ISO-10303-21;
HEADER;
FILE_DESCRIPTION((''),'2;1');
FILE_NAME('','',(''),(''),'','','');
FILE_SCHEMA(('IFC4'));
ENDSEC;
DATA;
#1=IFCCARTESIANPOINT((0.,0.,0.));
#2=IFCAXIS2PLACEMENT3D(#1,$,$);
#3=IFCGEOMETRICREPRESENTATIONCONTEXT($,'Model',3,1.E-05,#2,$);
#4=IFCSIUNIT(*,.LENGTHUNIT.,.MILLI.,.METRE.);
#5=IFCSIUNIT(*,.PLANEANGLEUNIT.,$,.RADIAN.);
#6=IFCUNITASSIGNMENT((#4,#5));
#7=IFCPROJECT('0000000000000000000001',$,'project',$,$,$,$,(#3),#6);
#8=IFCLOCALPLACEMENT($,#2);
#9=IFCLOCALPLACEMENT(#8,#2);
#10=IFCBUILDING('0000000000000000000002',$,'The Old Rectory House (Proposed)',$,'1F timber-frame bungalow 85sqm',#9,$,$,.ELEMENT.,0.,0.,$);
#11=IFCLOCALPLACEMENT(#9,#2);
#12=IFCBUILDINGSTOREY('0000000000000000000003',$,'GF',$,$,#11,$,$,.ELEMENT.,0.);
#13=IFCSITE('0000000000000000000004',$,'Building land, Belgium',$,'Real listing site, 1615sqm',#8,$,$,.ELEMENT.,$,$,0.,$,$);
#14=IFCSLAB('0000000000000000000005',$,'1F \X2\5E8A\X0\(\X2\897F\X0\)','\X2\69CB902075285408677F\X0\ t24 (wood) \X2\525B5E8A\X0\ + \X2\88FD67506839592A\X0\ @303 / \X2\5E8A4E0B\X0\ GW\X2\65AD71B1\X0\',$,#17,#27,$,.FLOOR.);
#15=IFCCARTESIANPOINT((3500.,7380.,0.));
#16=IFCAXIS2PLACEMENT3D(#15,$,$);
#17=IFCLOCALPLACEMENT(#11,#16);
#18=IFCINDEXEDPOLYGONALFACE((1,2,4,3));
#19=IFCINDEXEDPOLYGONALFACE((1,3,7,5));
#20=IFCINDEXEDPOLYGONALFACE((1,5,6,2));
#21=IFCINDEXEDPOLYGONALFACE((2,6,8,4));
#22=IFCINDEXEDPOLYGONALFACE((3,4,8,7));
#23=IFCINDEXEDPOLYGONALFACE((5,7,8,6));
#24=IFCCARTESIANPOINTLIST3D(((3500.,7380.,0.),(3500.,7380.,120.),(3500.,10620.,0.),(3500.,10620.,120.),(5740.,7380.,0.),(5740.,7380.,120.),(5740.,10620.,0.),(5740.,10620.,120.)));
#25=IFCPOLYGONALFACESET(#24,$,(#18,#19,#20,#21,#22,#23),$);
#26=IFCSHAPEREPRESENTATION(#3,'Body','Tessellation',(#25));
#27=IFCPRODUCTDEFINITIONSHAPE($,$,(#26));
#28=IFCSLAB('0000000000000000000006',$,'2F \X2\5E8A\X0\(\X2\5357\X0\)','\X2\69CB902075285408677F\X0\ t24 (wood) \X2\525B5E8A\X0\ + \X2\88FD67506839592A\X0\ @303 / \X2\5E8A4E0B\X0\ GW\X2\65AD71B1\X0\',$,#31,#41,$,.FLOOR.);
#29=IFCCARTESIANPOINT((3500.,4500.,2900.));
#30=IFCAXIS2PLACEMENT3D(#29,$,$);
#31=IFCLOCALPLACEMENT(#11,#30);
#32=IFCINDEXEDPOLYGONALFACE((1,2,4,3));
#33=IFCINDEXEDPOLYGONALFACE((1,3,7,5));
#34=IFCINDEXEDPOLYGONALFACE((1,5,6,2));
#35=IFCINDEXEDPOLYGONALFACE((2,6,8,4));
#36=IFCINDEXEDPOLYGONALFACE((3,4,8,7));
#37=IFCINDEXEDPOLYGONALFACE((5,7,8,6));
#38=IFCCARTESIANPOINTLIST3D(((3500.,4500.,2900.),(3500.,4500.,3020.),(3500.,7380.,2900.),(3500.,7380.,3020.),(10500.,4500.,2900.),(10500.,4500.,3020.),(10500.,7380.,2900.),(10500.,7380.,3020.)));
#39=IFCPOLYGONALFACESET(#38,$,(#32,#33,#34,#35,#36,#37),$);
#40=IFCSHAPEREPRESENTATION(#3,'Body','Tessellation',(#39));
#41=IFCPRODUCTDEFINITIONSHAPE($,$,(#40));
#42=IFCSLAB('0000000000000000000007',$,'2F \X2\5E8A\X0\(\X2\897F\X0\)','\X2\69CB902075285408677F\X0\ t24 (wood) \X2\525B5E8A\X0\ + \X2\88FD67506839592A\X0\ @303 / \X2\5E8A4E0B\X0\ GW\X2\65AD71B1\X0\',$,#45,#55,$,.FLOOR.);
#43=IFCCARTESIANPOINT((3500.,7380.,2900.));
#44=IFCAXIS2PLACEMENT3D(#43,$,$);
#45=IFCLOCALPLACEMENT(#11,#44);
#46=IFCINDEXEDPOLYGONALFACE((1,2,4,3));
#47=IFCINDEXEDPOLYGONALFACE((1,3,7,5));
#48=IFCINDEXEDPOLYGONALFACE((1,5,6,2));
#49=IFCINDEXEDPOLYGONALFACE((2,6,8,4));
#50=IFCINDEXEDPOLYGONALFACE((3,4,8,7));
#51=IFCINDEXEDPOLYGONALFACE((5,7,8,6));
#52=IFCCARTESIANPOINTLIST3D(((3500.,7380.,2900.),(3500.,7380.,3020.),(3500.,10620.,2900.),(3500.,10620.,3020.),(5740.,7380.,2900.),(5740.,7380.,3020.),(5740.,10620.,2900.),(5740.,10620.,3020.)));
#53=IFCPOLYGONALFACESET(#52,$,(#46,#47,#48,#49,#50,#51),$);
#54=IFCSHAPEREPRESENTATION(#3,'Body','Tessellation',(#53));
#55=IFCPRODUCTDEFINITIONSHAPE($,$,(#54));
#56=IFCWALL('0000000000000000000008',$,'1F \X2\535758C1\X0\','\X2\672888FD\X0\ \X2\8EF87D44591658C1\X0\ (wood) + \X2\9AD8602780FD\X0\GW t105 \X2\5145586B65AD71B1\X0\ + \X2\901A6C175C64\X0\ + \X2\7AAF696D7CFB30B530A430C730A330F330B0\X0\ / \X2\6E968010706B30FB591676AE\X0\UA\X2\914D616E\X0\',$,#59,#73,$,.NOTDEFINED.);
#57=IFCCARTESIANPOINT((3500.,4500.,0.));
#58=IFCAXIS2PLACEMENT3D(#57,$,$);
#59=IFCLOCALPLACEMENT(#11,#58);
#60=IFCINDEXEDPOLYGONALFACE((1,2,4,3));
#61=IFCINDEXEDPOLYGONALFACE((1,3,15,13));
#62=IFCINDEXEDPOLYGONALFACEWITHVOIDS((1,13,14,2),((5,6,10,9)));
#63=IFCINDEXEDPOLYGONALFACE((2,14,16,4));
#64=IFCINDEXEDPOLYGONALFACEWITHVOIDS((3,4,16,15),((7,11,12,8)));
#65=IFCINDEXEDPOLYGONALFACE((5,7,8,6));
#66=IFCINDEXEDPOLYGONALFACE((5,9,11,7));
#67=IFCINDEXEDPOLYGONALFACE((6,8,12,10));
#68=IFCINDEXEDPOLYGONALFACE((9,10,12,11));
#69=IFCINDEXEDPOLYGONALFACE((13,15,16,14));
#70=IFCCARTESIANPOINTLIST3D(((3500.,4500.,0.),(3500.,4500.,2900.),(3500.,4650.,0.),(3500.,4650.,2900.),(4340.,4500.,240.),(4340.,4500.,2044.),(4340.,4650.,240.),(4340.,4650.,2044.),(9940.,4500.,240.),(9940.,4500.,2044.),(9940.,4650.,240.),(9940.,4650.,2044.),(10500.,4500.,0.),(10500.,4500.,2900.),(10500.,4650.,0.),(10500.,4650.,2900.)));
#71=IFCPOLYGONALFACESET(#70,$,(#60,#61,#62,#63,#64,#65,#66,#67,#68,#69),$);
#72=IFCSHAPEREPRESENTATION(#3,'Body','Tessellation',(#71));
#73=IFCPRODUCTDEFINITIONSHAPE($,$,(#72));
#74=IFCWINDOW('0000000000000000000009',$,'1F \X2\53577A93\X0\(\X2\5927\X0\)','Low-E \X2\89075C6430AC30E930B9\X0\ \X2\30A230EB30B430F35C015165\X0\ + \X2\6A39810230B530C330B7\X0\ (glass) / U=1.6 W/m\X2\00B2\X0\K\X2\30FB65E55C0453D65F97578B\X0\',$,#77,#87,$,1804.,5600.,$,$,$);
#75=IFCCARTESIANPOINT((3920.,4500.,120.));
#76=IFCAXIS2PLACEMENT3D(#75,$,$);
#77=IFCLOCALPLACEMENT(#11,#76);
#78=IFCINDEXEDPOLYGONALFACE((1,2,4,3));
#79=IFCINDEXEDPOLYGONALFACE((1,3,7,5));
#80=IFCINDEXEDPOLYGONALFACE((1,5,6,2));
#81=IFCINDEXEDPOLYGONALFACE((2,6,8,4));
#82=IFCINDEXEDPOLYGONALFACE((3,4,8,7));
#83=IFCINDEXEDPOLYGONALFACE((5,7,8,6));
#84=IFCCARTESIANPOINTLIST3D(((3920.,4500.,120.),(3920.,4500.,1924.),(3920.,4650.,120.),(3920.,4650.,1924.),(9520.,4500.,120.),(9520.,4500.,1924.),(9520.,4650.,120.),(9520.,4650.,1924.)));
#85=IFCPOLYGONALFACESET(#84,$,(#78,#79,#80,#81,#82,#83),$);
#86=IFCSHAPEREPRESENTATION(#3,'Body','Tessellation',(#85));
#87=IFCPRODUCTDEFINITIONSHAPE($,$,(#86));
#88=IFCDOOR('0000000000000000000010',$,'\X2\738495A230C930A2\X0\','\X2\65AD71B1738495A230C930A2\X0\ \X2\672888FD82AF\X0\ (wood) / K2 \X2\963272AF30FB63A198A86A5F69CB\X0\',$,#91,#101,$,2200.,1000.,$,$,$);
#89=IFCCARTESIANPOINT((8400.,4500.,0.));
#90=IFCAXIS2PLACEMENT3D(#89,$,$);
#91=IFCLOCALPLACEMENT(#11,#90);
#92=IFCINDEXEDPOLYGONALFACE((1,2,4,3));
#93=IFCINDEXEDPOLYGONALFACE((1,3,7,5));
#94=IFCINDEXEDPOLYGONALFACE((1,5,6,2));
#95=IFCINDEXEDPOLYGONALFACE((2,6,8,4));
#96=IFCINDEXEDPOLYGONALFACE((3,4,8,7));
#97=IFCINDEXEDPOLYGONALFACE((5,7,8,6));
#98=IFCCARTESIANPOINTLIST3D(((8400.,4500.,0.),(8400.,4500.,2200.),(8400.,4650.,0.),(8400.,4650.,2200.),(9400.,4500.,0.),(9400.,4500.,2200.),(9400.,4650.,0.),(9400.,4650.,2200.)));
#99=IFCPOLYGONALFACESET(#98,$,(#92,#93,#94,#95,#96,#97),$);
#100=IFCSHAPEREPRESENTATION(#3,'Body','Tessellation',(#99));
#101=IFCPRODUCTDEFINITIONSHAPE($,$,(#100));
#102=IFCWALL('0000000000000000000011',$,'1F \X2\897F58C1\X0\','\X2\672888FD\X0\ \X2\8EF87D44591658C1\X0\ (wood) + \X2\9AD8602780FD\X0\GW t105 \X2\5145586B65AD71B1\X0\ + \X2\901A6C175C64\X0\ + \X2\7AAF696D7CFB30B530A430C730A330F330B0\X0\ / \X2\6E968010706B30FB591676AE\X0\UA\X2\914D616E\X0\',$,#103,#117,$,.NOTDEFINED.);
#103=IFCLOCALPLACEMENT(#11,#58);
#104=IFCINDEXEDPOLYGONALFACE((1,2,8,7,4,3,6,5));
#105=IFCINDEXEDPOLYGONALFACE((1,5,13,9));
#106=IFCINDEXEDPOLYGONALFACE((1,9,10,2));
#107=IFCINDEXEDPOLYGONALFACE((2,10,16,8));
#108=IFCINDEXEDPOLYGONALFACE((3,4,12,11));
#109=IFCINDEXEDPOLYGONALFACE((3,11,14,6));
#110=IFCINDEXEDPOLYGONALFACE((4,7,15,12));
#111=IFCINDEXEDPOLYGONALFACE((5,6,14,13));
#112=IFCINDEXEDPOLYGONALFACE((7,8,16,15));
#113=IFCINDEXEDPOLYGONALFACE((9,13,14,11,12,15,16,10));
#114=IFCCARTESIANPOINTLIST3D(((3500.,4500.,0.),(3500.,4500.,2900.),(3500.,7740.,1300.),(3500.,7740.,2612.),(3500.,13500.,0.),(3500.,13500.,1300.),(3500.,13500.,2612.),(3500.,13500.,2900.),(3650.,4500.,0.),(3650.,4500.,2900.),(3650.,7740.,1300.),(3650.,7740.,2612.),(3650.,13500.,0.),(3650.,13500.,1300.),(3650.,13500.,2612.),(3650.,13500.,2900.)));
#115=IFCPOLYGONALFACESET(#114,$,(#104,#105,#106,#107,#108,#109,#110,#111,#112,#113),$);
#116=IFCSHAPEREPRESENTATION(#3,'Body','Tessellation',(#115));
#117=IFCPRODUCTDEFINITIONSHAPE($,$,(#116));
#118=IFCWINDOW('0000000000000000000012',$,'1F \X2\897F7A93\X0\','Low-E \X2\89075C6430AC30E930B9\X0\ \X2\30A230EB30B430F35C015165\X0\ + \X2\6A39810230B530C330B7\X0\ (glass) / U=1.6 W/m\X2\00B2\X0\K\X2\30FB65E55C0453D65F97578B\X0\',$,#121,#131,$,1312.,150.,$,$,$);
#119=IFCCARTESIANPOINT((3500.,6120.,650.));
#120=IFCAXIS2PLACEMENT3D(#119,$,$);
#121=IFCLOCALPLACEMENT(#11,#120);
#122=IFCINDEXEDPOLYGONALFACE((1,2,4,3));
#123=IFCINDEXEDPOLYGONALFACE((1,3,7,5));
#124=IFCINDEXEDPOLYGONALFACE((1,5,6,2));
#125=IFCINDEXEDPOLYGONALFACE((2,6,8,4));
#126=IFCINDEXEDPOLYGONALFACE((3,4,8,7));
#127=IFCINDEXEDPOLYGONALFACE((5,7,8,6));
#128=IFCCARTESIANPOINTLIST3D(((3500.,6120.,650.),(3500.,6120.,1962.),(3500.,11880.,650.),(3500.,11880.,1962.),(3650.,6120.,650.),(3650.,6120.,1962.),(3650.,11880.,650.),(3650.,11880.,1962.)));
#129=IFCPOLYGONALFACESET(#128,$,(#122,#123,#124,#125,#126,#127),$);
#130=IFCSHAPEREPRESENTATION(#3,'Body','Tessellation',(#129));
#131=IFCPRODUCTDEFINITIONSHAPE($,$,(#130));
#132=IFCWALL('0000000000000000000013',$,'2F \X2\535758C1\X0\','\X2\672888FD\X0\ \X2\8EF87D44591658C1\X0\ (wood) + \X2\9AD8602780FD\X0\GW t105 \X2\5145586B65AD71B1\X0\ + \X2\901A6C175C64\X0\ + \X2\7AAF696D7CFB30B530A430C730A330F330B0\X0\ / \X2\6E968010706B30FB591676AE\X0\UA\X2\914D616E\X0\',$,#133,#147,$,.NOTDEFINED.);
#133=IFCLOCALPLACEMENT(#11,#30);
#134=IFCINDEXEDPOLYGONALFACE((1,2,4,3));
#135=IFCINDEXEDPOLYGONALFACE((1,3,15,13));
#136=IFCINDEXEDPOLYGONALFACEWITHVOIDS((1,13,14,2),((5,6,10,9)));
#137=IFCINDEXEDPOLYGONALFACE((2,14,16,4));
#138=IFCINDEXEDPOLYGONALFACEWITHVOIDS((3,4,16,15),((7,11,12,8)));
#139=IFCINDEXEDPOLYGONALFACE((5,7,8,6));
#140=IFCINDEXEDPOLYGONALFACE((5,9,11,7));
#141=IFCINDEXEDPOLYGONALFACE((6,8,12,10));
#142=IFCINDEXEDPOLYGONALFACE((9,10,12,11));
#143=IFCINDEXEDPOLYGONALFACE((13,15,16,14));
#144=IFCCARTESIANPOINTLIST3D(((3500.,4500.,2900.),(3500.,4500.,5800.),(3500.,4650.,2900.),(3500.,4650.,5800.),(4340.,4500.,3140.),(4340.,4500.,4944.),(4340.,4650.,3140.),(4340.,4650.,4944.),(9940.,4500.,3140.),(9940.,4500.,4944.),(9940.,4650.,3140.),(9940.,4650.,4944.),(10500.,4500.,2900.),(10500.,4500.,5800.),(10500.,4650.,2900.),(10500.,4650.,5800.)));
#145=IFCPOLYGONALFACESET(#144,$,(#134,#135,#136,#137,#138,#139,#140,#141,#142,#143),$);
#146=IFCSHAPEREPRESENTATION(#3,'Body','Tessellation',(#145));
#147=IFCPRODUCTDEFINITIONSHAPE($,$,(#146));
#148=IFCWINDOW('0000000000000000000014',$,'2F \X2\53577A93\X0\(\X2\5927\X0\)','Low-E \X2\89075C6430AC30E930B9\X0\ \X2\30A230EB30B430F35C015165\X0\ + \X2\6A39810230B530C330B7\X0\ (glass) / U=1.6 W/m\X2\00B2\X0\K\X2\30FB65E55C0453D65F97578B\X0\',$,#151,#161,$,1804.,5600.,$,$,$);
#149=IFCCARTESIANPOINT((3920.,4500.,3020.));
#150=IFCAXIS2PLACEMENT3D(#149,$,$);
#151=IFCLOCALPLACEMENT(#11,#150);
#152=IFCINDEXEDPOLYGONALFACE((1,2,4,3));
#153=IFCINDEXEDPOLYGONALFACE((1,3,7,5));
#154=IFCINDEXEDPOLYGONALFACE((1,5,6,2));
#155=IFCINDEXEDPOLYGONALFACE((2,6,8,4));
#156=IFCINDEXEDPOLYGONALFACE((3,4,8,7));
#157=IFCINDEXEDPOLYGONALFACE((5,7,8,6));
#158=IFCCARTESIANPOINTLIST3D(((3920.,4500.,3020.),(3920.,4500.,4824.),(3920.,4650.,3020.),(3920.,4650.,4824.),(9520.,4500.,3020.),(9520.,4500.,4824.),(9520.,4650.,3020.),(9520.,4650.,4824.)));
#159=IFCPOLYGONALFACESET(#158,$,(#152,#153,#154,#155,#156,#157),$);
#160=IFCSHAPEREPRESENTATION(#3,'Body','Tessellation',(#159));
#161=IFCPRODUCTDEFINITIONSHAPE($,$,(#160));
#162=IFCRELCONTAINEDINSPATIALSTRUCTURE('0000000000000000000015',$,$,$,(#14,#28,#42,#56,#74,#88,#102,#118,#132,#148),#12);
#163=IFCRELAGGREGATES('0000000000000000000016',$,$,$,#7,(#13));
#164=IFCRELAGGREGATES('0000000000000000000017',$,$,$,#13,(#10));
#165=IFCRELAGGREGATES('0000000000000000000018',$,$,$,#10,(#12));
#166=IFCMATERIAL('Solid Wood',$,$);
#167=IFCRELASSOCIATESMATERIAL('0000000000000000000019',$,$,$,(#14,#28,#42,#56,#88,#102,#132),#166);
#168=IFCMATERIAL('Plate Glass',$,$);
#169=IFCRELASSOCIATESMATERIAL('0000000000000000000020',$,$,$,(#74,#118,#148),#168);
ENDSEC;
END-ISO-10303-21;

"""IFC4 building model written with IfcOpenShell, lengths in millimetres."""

from ifc_helpers import new_model, si_unit, frame, frame_2d, origin, place, context, project, spatial, rectangle, extrude, material, element, fill, save


model = new_model("IFC4")

# Units and contexts
model_context = context("Model", 3, precision=1e-05, world=origin())
ifc_project = project(units=[si_unit("LENGTHUNIT", "METRE", prefix="MILLI"), si_unit("PLANEANGLEUNIT", "RADIAN")], contexts=[model_context])

# Site, building, storey
site_placement = place(None, origin())
site = spatial("IfcSite", under=ifc_project, at=site_placement, Name="Building land, Belgium", ObjectType="Real listing site, 1615sqm", CompositionType="ELEMENT", RefElevation=0.0)
building_placement = place(site_placement, origin())
building = spatial("IfcBuilding", under=site, at=building_placement, Name="The Old Rectory House (Proposed)", ObjectType="1F timber-frame bungalow 85sqm", CompositionType="ELEMENT", ElevationOfRefHeight=0.0, ElevationOfTerrain=0.0)
storey_placement = place(building_placement, origin())
storey = spatial("IfcBuildingStorey", under=building, at=storey_placement, Name="GF", CompositionType="ELEMENT", Elevation=0.0)

# Slabs
ifc_material_1 = material(Name="Solid Wood")
slab_1_placement = place(storey_placement, frame((3500.0, 7380.0, 0.0)))
element("IfcSlab", 1, at=slab_1_placement, inside=storey, material=ifc_material_1, Name="1F 床(西)", Description="構造用合板 t24 (wood) 剛床 + 製材根太 @303 / 床下 GW断熱", PredefinedType="FLOOR", context=model_context, shape_type="SweptSolid", body=[
    extrude(rectangle(XDim=2240.0, YDim=3240.0, at=frame_2d((1120.0, 1620.0))), frame((3500.0, 7380.0, 0.0)), (0.0, 0.0, 1.0), 120.0),
])
slab_2_placement = place(storey_placement, frame((3500.0, 4500.0, 2900.0)))
element("IfcSlab", 2, at=slab_2_placement, inside=storey, material=ifc_material_1, Name="2F 床(南)", Description="構造用合板 t24 (wood) 剛床 + 製材根太 @303 / 床下 GW断熱", PredefinedType="FLOOR", context=model_context, shape_type="SweptSolid", body=[
    extrude(rectangle(XDim=7000.0, YDim=2880.0, at=frame_2d((3500.0, 1440.0))), frame((3500.0, 4500.0, 2900.0)), (0.0, 0.0, 1.0), 120.0),
])
slab_3_placement = place(storey_placement, frame((3500.0, 7380.0, 2900.0)))
element("IfcSlab", 3, at=slab_3_placement, inside=storey, material=ifc_material_1, Name="2F 床(西)", Description="構造用合板 t24 (wood) 剛床 + 製材根太 @303 / 床下 GW断熱", PredefinedType="FLOOR", context=model_context, shape_type="SweptSolid", body=[
    extrude(rectangle(XDim=2240.0, YDim=3240.0, at=frame_2d((1120.0, 1620.0))), frame((3500.0, 7380.0, 2900.0)), (0.0, 0.0, 1.0), 120.0),
])

# Wall, openings, window, door
wall_1_placement = place(storey_placement, frame((3500.0, 4500.0, 0.0)))
wall_1 = element("IfcWall", 4, at=wall_1_placement, inside=storey, material=ifc_material_1, Name="1F 南壁", Description="木製 軸組外壁 (wood) + 高性能GW t105 充填断熱 + 通気層 + 窯業系サイディング / 準耐火・外皮UA配慮", PredefinedType="NOTDEFINED", context=model_context, shape_type="SweptSolid", body=[
    extrude(rectangle(XDim=7000.0, YDim=150.0, at=frame_2d((3500.0, 75.0))), frame((3500.0, 4500.0, 0.0)), (0.0, 0.0, 1.0), 2900.0),
])
opening_1_placement = place(storey_placement, frame((3920.0, 4500.0, 120.0)))
opening_1 = element("IfcOpeningElement", 5, at=opening_1_placement, cuts=wall_1, PredefinedType="NOTDEFINED", context=model_context, shape_type="SweptSolid", body=[
    extrude(rectangle(XDim=5600.0, YDim=150.0, at=frame_2d((2800.0, 75.0))), frame((3920.0, 4500.0, 120.0)), (0.0, 0.0, 1.0), 1804.0),
])
opening_2_placement = place(storey_placement, frame((8400.0, 4500.0, 0.0)))
opening_2 = element("IfcOpeningElement", 6, at=opening_2_placement, cuts=wall_1, PredefinedType="NOTDEFINED", context=model_context, shape_type="SweptSolid", body=[
    extrude(rectangle(XDim=1000.0, YDim=150.0, at=frame_2d((500.0, 75.0))), frame((8400.0, 4500.0, 0.0)), (0.0, 0.0, 1.0), 2200.0),
])
ifc_material_2 = material(Name="Plate Glass")
window_1_placement = place(storey_placement, frame((3920.0, 4500.0, 120.0)))
window_1 = element("IfcWindow", 7, at=window_1_placement, inside=storey, material=ifc_material_2, Name="1F 南窓(大)", Description="Low-E 複層ガラス アルゴン封入 + 樹脂サッシ (glass) / U=1.6 W/m²K・日射取得型", OverallHeight=1804.0, OverallWidth=5600.0, context=model_context, shape_type="SweptSolid", body=[
    extrude(rectangle(XDim=5600.0, YDim=150.0, at=frame_2d((2800.0, 75.0))), frame((3920.0, 4500.0, 120.0)), (0.0, 0.0, 1.0), 1804.0),
])
fill(opening_1, window_1)
door_placement = place(storey_placement, frame((8400.0, 4500.0, 0.0)))
door = element("IfcDoor", 8, at=door_placement, inside=storey, material=ifc_material_1, Name="玄関ドア", Description="断熱玄関ドア 木製芯 (wood) / K2 防犯・採風機構", OverallHeight=2200.0, OverallWidth=1000.0, context=model_context, shape_type="SweptSolid", body=[
    extrude(rectangle(XDim=1000.0, YDim=150.0, at=frame_2d((500.0, 75.0))), frame((8400.0, 4500.0, 0.0)), (0.0, 0.0, 1.0), 2200.0),
])
fill(opening_2, door)

# Walls, openings, windows
wall_2_placement = place(storey_placement, frame((3500.0, 4500.0, 0.0)))
wall_2 = element("IfcWall", 9, at=wall_2_placement, inside=storey, material=ifc_material_1, Name="1F 西壁", Description="木製 軸組外壁 (wood) + 高性能GW t105 充填断熱 + 通気層 + 窯業系サイディング / 準耐火・外皮UA配慮", PredefinedType="NOTDEFINED", context=model_context, shape_type="SweptSolid", body=[
    extrude(rectangle(XDim=150.0, YDim=9000.0, at=frame_2d((75.0, 4500.0))), frame((3500.0, 4500.0, 0.0)), (0.0, 0.0, 1.0), 2900.0),
])
opening_3_placement = place(storey_placement, frame((3500.0, 6120.0, 650.0)))
opening_3 = element("IfcOpeningElement", 10, at=opening_3_placement, cuts=wall_2, PredefinedType="NOTDEFINED", context=model_context, shape_type="SweptSolid", body=[
    extrude(rectangle(XDim=150.0, YDim=5760.0, at=frame_2d((75.0, 2880.0))), frame((3500.0, 6120.0, 650.0)), (0.0, 0.0, 1.0), 1312.0),
])
window_2_placement = place(storey_placement, frame((3500.0, 6120.0, 650.0)))
window_2 = element("IfcWindow", 11, at=window_2_placement, inside=storey, material=ifc_material_2, Name="1F 西窓", Description="Low-E 複層ガラス アルゴン封入 + 樹脂サッシ (glass) / U=1.6 W/m²K・日射取得型", OverallHeight=1312.0, OverallWidth=150.0, context=model_context, shape_type="SweptSolid", body=[
    extrude(rectangle(XDim=150.0, YDim=5760.0, at=frame_2d((75.0, 2880.0))), frame((3500.0, 6120.0, 650.0)), (0.0, 0.0, 1.0), 1312.0),
])
fill(opening_3, window_2)
wall_3_placement = place(storey_placement, frame((3500.0, 4500.0, 2900.0)))
wall_3 = element("IfcWall", 12, at=wall_3_placement, inside=storey, material=ifc_material_1, Name="2F 南壁", Description="木製 軸組外壁 (wood) + 高性能GW t105 充填断熱 + 通気層 + 窯業系サイディング / 準耐火・外皮UA配慮", PredefinedType="NOTDEFINED", context=model_context, shape_type="SweptSolid", body=[
    extrude(rectangle(XDim=7000.0, YDim=150.0, at=frame_2d((3500.0, 75.0))), frame((3500.0, 4500.0, 2900.0)), (0.0, 0.0, 1.0), 2900.0),
])
opening_4_placement = place(storey_placement, frame((3920.0, 4500.0, 3020.0)))
opening_4 = element("IfcOpeningElement", 13, at=opening_4_placement, cuts=wall_3, PredefinedType="NOTDEFINED", context=model_context, shape_type="SweptSolid", body=[
    extrude(rectangle(XDim=5600.0, YDim=150.0, at=frame_2d((2800.0, 75.0))), frame((3920.0, 4500.0, 3020.0)), (0.0, 0.0, 1.0), 1804.0),
])
window_3_placement = place(storey_placement, frame((3920.0, 4500.0, 3020.0)))
window_3 = element("IfcWindow", 14, at=window_3_placement, inside=storey, material=ifc_material_2, Name="2F 南窓(大)", Description="Low-E 複層ガラス アルゴン封入 + 樹脂サッシ (glass) / U=1.6 W/m²K・日射取得型", OverallHeight=1804.0, OverallWidth=5600.0, context=model_context, shape_type="SweptSolid", body=[
    extrude(rectangle(XDim=5600.0, YDim=150.0, at=frame_2d((2800.0, 75.0))), frame((3920.0, 4500.0, 3020.0)), (0.0, 0.0, 1.0), 1804.0),
])
fill(opening_4, window_3)

save(model, "model.ifc")
